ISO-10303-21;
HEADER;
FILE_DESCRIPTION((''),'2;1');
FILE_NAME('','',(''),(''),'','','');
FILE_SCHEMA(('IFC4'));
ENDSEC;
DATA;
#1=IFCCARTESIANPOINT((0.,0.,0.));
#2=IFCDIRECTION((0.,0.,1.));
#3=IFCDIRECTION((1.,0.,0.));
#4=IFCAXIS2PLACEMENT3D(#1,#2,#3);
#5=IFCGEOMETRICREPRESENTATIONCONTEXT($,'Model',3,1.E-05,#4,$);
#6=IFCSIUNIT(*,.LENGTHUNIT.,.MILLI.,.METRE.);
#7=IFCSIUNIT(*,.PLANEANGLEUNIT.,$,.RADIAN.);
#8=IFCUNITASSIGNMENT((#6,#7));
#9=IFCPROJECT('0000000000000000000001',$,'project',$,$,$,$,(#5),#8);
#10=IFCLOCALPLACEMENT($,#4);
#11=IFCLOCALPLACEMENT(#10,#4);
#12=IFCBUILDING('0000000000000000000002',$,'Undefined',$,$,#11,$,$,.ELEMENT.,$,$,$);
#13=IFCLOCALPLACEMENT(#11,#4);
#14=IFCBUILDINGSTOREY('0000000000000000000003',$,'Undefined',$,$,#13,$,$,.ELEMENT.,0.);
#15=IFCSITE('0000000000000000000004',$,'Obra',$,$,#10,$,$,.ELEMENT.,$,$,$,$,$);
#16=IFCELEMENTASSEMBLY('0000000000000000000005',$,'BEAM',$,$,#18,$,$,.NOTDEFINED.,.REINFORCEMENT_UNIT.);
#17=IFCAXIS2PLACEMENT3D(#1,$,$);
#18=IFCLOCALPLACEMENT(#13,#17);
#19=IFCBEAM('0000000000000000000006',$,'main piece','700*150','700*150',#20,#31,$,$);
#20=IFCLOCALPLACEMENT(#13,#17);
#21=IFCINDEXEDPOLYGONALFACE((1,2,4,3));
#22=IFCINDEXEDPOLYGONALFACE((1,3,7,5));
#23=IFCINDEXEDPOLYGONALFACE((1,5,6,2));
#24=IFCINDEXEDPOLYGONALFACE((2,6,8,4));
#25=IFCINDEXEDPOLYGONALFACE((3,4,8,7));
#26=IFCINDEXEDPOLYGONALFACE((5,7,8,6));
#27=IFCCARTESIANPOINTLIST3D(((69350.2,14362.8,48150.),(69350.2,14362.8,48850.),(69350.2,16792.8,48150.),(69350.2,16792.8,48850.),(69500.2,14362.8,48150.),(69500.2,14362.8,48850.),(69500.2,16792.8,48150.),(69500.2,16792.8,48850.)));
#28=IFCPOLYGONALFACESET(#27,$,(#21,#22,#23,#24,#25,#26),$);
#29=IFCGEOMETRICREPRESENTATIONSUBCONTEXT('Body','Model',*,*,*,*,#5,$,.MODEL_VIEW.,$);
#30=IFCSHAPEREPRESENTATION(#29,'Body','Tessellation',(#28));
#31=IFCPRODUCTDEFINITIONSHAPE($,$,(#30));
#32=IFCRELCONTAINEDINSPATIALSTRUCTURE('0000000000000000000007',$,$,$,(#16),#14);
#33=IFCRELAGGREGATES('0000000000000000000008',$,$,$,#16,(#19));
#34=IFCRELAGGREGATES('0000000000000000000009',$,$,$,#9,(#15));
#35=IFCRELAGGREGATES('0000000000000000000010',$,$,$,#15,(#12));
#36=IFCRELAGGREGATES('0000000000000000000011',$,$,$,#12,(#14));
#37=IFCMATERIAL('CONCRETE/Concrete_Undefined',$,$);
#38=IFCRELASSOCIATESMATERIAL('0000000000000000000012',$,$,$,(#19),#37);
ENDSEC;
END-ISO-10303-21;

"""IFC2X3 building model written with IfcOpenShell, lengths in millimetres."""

from ifc_helpers import new_model, si_unit, frame, origin_with_axes, origin_2d_with_axis, place, context, subcontext, project, spatial, rectangle, extrude, material, element, aggregate, save


model = new_model("IFC2X3")

# Units and contexts
model_context = context("Model", 3, precision=1e-05, world=origin_with_axes())
body_context = subcontext(model_context, "Body", "Model", "MODEL_VIEW")
ifc_project = project(units=[si_unit("LENGTHUNIT", "METRE", prefix="MILLI"), si_unit("PLANEANGLEUNIT", "RADIAN")], contexts=[model_context])

# Site, building, storey
site_placement = place(None, origin_with_axes())
site = spatial("IfcSite", under=ifc_project, at=site_placement, Name="Obra", CompositionType="ELEMENT")
building_placement = place(site_placement, origin_with_axes())
building = spatial("IfcBuilding", under=site, at=building_placement, Name="Undefined", CompositionType="ELEMENT")
storey_placement = place(building_placement, origin_with_axes())
storey = spatial("IfcBuildingStorey", under=building, at=storey_placement, Name="Undefined", CompositionType="ELEMENT", Elevation=0.0)

# Element assembly, beam
ifc_material_1 = material(Name="CONCRETE/Concrete_Undefined")
assembly_1_placement = place(storey_placement, origin_with_axes())
assembly_1 = element("IfcElementAssembly", 1, at=assembly_1_placement, inside=storey, Name="BEAM", AssemblyPlace="NOTDEFINED", PredefinedType="REINFORCEMENT_UNIT")
beam_1_placement = place(assembly_1_placement, frame((69425.2, 14362.8, 48500.0), z_axis=(0.0, 0.0, 1.0), x_axis=(0.0, 1.0, 0.0)))
beam_1 = element("IfcBeam", 2, at=beam_1_placement, material=ifc_material_1, Name="main piece", Description="700*150", ObjectType="700*150", context=body_context, shape_type="SweptSolid", body=[
    extrude(rectangle(XDim=150.0, YDim=700.0, at=origin_2d_with_axis()), frame((2429.9, 0.0, 0.0), z_axis=(-1.0, 0.0, 0.0), x_axis=(0.0, -1.0, 0.0)), (0.0, 0.0, 1.0), 2429.9),
])
aggregate(assembly_1, [beam_1])

save(model, "model.ifc")
